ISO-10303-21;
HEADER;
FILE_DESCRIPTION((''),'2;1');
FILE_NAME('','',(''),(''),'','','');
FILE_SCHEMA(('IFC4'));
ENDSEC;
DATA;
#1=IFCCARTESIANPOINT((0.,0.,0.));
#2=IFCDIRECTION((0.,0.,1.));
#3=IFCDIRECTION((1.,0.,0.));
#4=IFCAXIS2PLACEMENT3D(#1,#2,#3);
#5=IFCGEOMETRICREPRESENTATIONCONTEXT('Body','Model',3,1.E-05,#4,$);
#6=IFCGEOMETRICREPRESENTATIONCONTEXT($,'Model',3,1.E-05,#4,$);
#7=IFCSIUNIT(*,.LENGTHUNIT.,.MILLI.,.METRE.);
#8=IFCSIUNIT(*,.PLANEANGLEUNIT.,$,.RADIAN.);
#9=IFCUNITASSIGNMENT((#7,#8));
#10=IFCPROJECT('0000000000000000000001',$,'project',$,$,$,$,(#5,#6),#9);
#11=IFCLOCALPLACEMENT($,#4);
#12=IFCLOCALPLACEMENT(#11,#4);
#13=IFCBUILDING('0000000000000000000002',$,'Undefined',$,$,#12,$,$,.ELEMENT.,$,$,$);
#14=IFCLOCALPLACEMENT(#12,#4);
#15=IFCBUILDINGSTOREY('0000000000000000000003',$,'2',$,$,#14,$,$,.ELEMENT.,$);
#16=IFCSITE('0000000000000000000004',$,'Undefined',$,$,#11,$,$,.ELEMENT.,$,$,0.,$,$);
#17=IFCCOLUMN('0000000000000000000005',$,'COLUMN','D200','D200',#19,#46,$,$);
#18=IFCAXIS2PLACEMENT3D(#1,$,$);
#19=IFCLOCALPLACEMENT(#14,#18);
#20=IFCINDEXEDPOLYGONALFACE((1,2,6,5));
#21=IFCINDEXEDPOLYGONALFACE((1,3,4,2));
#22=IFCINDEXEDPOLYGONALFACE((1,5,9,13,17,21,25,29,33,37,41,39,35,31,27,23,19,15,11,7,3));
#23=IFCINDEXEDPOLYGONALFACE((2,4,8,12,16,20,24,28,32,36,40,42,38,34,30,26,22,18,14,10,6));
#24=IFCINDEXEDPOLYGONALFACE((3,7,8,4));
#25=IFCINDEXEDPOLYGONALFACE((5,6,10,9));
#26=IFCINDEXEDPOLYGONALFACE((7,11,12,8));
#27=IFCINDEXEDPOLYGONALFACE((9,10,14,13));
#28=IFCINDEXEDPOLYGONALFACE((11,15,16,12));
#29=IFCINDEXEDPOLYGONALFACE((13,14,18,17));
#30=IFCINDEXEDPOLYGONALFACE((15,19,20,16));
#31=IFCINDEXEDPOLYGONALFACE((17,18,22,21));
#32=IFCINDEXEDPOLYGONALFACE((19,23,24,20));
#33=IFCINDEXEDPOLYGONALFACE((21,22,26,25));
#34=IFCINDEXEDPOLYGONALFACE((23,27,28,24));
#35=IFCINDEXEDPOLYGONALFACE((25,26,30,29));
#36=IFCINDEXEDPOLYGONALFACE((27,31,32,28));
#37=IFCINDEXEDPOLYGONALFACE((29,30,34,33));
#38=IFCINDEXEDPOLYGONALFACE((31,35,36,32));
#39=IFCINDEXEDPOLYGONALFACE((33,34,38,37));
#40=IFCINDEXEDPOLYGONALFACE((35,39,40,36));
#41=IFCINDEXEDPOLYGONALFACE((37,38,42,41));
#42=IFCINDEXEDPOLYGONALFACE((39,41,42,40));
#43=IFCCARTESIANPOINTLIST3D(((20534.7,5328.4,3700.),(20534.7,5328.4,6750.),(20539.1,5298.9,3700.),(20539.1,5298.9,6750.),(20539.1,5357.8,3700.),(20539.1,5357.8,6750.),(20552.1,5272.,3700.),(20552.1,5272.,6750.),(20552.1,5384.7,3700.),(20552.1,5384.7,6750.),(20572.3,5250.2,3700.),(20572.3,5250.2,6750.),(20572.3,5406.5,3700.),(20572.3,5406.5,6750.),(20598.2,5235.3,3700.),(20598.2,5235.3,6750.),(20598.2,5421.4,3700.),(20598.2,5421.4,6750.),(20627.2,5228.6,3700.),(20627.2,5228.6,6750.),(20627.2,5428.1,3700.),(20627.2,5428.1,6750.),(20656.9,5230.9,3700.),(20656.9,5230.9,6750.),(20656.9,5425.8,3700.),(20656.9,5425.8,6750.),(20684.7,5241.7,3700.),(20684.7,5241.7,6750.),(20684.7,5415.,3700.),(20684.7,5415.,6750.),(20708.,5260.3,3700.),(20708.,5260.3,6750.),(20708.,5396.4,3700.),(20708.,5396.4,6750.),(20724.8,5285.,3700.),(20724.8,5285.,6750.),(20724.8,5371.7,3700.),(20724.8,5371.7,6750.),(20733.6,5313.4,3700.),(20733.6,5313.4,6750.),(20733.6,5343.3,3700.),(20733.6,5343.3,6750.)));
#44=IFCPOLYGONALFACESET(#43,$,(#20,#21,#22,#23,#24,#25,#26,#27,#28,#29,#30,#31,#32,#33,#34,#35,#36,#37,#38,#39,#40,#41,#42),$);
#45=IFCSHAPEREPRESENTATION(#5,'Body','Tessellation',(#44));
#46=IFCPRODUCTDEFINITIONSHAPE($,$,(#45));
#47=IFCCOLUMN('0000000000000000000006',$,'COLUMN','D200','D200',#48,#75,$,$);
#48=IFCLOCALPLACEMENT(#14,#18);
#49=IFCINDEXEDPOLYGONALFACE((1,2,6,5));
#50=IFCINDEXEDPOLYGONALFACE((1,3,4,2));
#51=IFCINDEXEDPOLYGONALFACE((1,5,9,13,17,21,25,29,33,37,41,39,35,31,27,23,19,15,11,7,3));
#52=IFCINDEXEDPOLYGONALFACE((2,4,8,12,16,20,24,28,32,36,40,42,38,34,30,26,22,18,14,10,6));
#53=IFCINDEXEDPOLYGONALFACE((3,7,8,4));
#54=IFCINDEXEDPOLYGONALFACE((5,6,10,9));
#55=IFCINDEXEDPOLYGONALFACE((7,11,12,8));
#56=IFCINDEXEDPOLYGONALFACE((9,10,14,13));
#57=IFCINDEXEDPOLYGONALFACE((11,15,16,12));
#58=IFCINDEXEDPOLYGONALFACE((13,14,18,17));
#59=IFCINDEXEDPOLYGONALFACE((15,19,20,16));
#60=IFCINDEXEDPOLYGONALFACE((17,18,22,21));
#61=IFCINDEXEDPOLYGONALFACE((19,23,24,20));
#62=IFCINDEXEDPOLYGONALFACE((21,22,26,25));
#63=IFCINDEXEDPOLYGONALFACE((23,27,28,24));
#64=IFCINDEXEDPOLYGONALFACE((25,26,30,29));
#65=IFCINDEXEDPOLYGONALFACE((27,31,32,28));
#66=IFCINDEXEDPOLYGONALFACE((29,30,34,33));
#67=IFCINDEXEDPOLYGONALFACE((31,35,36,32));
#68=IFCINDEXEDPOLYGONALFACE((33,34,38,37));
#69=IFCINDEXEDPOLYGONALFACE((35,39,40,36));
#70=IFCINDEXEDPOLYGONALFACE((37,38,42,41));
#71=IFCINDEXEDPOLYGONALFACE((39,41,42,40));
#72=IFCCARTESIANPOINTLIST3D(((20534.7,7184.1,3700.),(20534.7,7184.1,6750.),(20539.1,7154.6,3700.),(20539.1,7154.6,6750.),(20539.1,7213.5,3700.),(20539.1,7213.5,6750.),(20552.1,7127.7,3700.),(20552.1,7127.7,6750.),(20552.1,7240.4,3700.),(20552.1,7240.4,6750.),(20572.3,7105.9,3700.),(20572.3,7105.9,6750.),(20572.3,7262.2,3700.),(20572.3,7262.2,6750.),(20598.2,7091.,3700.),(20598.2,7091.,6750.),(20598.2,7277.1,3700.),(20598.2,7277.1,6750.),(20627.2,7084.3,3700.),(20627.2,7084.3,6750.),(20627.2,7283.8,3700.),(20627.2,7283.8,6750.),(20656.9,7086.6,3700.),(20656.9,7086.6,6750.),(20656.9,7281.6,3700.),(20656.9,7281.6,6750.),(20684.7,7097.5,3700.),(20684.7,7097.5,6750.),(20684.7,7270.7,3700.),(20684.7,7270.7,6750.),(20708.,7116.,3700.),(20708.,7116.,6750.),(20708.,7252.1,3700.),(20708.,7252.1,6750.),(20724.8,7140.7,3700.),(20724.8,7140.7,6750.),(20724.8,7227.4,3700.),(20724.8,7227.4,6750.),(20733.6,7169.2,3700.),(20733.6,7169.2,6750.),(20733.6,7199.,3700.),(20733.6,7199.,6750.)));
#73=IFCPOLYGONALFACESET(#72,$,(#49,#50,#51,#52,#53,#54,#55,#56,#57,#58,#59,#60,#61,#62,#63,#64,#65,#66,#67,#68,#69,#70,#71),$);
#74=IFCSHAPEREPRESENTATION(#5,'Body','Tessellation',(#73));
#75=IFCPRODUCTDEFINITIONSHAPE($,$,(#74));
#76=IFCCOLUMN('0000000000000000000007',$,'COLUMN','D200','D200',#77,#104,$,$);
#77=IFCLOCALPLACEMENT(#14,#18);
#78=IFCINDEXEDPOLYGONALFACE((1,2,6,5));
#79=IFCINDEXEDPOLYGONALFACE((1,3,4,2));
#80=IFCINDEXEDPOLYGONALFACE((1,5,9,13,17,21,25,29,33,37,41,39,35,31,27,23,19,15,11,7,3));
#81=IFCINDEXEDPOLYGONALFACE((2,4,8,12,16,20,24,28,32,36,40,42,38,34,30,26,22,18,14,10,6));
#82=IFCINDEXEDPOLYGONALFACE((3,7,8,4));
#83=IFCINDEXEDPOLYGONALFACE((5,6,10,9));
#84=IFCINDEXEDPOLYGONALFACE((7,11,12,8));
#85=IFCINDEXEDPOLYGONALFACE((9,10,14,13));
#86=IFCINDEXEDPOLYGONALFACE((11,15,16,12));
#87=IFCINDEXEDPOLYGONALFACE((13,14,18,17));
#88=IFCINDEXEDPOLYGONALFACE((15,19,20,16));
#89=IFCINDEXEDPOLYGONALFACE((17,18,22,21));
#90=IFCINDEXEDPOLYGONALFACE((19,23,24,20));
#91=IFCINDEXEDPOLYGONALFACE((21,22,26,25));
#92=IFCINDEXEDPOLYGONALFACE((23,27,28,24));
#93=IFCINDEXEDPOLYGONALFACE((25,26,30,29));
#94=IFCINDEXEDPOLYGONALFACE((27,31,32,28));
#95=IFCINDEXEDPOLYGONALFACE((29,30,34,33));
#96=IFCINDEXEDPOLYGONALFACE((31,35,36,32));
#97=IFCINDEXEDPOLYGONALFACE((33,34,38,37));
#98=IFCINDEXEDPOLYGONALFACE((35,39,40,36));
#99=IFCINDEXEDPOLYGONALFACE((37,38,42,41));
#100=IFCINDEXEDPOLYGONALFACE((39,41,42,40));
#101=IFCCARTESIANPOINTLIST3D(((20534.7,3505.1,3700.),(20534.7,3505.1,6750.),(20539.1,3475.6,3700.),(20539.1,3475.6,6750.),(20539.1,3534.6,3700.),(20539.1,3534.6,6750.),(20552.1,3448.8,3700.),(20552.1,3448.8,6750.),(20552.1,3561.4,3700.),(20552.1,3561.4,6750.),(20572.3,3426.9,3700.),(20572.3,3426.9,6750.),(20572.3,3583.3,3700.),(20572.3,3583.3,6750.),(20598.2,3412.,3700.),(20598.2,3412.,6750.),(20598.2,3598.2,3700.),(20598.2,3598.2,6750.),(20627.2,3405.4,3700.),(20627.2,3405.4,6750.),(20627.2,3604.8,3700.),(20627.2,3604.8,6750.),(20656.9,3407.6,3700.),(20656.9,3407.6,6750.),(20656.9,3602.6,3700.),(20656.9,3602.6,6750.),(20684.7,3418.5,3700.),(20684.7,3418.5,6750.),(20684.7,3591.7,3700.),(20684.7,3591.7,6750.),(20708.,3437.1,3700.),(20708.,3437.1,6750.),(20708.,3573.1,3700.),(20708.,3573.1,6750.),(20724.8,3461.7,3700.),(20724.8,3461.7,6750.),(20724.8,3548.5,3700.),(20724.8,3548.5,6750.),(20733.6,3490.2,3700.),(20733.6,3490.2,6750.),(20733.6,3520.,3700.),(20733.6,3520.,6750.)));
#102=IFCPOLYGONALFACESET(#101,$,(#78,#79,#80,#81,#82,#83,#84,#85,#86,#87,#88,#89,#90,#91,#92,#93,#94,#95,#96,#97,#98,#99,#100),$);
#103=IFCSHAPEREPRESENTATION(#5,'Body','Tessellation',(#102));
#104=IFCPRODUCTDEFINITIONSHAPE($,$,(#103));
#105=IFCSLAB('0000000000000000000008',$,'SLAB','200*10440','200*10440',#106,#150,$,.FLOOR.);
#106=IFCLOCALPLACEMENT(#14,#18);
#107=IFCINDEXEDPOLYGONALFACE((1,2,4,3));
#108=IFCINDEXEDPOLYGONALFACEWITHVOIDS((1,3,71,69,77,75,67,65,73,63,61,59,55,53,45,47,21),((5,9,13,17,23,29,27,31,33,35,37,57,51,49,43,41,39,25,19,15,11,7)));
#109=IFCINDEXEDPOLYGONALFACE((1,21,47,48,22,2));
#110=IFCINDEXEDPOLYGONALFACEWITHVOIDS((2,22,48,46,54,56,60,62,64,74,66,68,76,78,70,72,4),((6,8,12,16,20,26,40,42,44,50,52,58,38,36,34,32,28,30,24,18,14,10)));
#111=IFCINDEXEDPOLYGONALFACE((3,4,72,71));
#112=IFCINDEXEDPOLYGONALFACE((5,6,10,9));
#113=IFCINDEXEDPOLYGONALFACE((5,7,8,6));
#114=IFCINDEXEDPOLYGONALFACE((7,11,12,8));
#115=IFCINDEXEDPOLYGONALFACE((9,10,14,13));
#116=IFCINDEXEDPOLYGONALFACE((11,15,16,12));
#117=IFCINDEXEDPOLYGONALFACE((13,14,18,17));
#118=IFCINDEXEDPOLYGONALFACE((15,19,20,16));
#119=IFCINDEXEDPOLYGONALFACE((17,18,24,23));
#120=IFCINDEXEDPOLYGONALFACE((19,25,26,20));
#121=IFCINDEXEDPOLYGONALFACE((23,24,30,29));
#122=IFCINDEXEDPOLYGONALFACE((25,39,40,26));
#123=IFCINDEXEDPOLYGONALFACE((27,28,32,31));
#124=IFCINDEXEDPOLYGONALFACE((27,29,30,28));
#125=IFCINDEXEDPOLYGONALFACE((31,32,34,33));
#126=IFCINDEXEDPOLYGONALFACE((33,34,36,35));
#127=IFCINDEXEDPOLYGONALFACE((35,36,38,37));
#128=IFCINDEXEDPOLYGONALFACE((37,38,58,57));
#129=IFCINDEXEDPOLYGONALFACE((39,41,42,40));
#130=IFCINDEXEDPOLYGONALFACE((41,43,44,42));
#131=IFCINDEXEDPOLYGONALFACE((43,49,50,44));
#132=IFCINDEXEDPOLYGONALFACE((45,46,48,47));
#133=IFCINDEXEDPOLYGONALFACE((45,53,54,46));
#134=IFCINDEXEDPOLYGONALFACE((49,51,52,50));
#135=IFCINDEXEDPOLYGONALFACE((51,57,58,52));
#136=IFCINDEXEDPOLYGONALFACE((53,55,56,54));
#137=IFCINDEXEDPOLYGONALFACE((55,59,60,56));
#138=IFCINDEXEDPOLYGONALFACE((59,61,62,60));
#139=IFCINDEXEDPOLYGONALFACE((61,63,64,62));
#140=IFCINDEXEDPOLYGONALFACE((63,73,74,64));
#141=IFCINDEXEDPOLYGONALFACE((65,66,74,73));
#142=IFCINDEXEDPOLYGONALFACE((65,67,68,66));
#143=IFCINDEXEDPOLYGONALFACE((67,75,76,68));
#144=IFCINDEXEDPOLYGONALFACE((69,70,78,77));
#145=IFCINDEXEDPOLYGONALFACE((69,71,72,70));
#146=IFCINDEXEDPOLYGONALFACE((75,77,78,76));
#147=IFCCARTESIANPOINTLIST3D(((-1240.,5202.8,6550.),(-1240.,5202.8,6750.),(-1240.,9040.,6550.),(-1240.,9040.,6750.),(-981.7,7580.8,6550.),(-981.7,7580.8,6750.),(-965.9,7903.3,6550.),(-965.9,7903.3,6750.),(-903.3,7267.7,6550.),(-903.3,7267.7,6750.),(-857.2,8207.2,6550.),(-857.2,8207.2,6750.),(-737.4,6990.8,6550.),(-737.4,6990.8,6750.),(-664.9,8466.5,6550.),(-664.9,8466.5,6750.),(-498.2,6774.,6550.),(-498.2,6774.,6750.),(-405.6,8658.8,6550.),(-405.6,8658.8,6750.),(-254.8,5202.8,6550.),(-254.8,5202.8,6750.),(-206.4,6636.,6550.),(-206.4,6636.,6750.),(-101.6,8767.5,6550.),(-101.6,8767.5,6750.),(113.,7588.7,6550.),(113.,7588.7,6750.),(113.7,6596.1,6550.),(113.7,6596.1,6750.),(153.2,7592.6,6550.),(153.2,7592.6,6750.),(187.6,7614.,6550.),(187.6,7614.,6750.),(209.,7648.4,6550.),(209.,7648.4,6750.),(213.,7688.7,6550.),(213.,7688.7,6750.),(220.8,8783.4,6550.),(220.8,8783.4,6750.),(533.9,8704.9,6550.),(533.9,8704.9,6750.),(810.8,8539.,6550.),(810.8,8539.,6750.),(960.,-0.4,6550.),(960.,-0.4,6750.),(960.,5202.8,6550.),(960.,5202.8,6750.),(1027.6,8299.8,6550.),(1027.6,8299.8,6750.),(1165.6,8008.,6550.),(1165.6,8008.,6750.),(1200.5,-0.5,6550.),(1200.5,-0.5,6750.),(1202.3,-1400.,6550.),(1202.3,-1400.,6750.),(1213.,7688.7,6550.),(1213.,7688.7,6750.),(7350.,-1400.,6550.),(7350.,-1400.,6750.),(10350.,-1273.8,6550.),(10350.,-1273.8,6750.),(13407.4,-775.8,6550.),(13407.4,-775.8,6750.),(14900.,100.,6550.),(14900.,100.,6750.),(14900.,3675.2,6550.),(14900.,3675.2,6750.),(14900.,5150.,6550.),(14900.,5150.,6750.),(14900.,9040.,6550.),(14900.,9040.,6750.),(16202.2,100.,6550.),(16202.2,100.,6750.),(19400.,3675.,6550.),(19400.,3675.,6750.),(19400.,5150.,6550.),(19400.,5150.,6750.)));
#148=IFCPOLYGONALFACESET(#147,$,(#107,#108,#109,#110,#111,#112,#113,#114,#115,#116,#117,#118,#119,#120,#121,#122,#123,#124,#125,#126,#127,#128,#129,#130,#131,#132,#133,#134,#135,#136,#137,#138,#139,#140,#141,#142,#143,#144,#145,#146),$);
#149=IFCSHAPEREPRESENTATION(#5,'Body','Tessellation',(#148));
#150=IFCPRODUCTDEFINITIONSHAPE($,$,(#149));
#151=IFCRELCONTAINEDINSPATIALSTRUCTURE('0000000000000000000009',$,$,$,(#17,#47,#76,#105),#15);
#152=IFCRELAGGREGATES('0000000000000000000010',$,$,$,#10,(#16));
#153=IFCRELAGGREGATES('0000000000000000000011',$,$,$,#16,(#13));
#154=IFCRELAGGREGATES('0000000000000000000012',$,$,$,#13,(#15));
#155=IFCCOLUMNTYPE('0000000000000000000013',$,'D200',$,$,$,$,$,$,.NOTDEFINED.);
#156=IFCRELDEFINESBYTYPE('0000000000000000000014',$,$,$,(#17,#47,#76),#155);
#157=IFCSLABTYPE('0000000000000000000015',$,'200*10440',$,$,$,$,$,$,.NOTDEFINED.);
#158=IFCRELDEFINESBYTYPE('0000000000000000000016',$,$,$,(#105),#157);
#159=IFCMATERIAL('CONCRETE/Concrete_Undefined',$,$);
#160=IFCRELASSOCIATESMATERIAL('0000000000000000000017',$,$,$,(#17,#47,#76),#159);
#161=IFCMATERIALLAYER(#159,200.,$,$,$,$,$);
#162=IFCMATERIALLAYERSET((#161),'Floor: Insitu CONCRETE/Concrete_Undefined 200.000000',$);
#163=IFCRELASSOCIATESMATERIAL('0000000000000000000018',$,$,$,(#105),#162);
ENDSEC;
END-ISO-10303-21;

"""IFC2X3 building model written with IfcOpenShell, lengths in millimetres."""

from ifc_helpers import new_model, si_unit, frame, origin_with_axes, origin_2d_with_axis, place, context, project, spatial, polyline, circle, outline, extrude, material, layer, layer_set, layer_usage, type_object, element, save


model = new_model("IFC2X3")

# Units and contexts
model_context_1 = context("Model", 3, precision=1e-05, world=origin_with_axes(), identifier="Body")
model_context_2 = context("Model", 3, precision=1e-05, world=origin_with_axes())
ifc_project = project(units=[si_unit("LENGTHUNIT", "METRE", prefix="MILLI"), si_unit("PLANEANGLEUNIT", "RADIAN")], contexts=[model_context_1, model_context_2])

# Site, building, storey
site_placement = place(None, origin_with_axes())
site = spatial("IfcSite", under=ifc_project, at=site_placement, Name="Undefined", CompositionType="ELEMENT", RefElevation=0.0)
building_placement = place(site_placement, origin_with_axes())
building = spatial("IfcBuilding", under=site, at=building_placement, Name="Undefined", CompositionType="ELEMENT")
storey_placement = place(building_placement, origin_with_axes())
storey = spatial("IfcBuildingStorey", under=building, at=storey_placement, Name="2", CompositionType="ELEMENT")

# Columns
ifc_material = material(Name="CONCRETE/Concrete_Undefined")
column_type = type_object("IfcColumnType", Name="D200", PredefinedType="NOTDEFINED")
for number, where, z_axis, x_axis, name in (
    (1, (20634.7, 5328.4, 3700.0), (0.0, 0.0, 1.0), (1.0, 0.0, 0.0), "COLUMN"),
    (2, (20634.7, 7184.1, 3700.0), (0.0, 0.0, 1.0), (1.0, 0.0, 0.0), "COLUMN"),
    (3, (20634.7, 3505.1, 3700.0), (0.0, 0.0, 1.0), (1.0, 0.0, 0.0), "COLUMN"),
):
    element("IfcColumn", number, at=place(storey_placement, frame(where, z_axis=z_axis, x_axis=x_axis)), inside=storey, type_object=column_type, material=ifc_material, Name=name, Description="D200", ObjectType="D200", context=model_context_1, shape_type="SweptSolid", body=[
        extrude(circle(Radius=100.0, at=origin_2d_with_axis()), frame((0.0, 0.0, 3050.0), z_axis=(0.0, 0.0, -1.0), x_axis=(-1.0, 0.0, 0.0)), (0.0, 0.0, 1.0), 3050.0),
    ])

# Slab, openings
ifc_layer_1 = layer(ifc_material, 200.0)
ifc_layer_set_1 = layer_set([ifc_layer_1], Name="Floor: Insitu CONCRETE/Concrete_Undefined 200.000000")
ifc_layer_usage_1 = layer_usage(ifc_layer_set_1, "AXIS3", "POSITIVE", -100.0)
slab_type = type_object("IfcSlabType", Name="200*10440", PredefinedType="NOTDEFINED")
slab_placement = place(storey_placement, frame((-1240.0, 9040.0, 6650.0), z_axis=(0.0, 0.0, 1.0), x_axis=(0.0, -1.0, 0.0)))
slab = element("IfcSlab", 4, at=slab_placement, inside=storey, type_object=slab_type, material=ifc_layer_usage_1, Name="SLAB", Description="200*10440", ObjectType="200*10440", PredefinedType="FLOOR", context=model_context_1, shape_type="SweptSolid", body=[
    extrude(outline(polyline([(0.0, 0.0), (3837.2, 0.0), (3837.2, 985.2), (9040.0, 1000.0), (9040.5, 2440.5), (10440.0, 2442.3), (10440.0, 8590.0), (10313.8, 11590.0), (9815.8, 14647.4), (8940.0, 17442.2), (8940.0, 16140.0), (5364.8, 16140.0), (5365.0, 20640.0), (3890.0, 20640.0), (3890.0, 16140.0), (0.0, 16140.0), (0.0, 0.0)])), frame((0.0, 0.0, -100.0), z_axis=(0.0, 0.0, 1.0), x_axis=(1.0, 0.0, 0.0)), (0.0, 0.0, 1.0), 200.0),
])
opening_1_placement = place(storey_placement, frame((-1240.0, 9040.0, 6650.0), z_axis=(0.0, 0.0, 1.0), x_axis=(0.0, -1.0, 0.0)))
element("IfcOpeningElement", 5, at=opening_1_placement, cuts=slab, ObjectType="Recess", context=model_context_1, shape_type="SweptSolid", body=[
    extrude(outline(polyline([(0.0, 0.0), (5202.8, 0.0), (5206.6, 1200.0), (3.4, 1214.8), (0.0, 0.0)])), frame((3837.2, 985.2, -103.0), z_axis=(0.0, 0.0, 1.0), x_axis=(0.999996, 0.002844, 0.0)), (0.0, 0.0, 1.0), 206.0),
])
opening_2_placement = place(storey_placement, frame((-1240.0, 9040.0, 6650.0), z_axis=(0.0, 0.0, 1.0), x_axis=(0.0, -1.0, 0.0)))
element("IfcOpeningElement", 6, at=opening_2_placement, cuts=slab, ObjectType="Recess", context=model_context_1, shape_type="SweptSolid", body=[
    extrude(outline(polyline([(0.0, 0.0), (992.5, 0.0), (952.4, 320.0), (814.2, 611.7), (597.2, 850.8), (320.2, 1016.5), (7.0, 1094.7), (-315.4, 1078.6), (-619.3, 969.7), (-878.4, 777.2), (-1070.5, 517.7), (-1179.0, 213.7), (-1194.6, -108.7), (-1116.0, -421.8), (-949.8, -698.5), (-710.5, -915.1), (-418.5, -1052.9), (-99.2, -1100.1), (-99.9, -100.1), (-59.7, -96.0), (-25.3, -74.6), (-4.0, -40.3), (0.0, 0.0)])), frame((1451.3, 1353.0, 102.5), z_axis=(0.0, 0.0, -1.0), x_axis=(1.0, 0.00074, 0.0)), (0.0, 0.0, 1.0), 205.0),
])

save(model, "model.ifc")
